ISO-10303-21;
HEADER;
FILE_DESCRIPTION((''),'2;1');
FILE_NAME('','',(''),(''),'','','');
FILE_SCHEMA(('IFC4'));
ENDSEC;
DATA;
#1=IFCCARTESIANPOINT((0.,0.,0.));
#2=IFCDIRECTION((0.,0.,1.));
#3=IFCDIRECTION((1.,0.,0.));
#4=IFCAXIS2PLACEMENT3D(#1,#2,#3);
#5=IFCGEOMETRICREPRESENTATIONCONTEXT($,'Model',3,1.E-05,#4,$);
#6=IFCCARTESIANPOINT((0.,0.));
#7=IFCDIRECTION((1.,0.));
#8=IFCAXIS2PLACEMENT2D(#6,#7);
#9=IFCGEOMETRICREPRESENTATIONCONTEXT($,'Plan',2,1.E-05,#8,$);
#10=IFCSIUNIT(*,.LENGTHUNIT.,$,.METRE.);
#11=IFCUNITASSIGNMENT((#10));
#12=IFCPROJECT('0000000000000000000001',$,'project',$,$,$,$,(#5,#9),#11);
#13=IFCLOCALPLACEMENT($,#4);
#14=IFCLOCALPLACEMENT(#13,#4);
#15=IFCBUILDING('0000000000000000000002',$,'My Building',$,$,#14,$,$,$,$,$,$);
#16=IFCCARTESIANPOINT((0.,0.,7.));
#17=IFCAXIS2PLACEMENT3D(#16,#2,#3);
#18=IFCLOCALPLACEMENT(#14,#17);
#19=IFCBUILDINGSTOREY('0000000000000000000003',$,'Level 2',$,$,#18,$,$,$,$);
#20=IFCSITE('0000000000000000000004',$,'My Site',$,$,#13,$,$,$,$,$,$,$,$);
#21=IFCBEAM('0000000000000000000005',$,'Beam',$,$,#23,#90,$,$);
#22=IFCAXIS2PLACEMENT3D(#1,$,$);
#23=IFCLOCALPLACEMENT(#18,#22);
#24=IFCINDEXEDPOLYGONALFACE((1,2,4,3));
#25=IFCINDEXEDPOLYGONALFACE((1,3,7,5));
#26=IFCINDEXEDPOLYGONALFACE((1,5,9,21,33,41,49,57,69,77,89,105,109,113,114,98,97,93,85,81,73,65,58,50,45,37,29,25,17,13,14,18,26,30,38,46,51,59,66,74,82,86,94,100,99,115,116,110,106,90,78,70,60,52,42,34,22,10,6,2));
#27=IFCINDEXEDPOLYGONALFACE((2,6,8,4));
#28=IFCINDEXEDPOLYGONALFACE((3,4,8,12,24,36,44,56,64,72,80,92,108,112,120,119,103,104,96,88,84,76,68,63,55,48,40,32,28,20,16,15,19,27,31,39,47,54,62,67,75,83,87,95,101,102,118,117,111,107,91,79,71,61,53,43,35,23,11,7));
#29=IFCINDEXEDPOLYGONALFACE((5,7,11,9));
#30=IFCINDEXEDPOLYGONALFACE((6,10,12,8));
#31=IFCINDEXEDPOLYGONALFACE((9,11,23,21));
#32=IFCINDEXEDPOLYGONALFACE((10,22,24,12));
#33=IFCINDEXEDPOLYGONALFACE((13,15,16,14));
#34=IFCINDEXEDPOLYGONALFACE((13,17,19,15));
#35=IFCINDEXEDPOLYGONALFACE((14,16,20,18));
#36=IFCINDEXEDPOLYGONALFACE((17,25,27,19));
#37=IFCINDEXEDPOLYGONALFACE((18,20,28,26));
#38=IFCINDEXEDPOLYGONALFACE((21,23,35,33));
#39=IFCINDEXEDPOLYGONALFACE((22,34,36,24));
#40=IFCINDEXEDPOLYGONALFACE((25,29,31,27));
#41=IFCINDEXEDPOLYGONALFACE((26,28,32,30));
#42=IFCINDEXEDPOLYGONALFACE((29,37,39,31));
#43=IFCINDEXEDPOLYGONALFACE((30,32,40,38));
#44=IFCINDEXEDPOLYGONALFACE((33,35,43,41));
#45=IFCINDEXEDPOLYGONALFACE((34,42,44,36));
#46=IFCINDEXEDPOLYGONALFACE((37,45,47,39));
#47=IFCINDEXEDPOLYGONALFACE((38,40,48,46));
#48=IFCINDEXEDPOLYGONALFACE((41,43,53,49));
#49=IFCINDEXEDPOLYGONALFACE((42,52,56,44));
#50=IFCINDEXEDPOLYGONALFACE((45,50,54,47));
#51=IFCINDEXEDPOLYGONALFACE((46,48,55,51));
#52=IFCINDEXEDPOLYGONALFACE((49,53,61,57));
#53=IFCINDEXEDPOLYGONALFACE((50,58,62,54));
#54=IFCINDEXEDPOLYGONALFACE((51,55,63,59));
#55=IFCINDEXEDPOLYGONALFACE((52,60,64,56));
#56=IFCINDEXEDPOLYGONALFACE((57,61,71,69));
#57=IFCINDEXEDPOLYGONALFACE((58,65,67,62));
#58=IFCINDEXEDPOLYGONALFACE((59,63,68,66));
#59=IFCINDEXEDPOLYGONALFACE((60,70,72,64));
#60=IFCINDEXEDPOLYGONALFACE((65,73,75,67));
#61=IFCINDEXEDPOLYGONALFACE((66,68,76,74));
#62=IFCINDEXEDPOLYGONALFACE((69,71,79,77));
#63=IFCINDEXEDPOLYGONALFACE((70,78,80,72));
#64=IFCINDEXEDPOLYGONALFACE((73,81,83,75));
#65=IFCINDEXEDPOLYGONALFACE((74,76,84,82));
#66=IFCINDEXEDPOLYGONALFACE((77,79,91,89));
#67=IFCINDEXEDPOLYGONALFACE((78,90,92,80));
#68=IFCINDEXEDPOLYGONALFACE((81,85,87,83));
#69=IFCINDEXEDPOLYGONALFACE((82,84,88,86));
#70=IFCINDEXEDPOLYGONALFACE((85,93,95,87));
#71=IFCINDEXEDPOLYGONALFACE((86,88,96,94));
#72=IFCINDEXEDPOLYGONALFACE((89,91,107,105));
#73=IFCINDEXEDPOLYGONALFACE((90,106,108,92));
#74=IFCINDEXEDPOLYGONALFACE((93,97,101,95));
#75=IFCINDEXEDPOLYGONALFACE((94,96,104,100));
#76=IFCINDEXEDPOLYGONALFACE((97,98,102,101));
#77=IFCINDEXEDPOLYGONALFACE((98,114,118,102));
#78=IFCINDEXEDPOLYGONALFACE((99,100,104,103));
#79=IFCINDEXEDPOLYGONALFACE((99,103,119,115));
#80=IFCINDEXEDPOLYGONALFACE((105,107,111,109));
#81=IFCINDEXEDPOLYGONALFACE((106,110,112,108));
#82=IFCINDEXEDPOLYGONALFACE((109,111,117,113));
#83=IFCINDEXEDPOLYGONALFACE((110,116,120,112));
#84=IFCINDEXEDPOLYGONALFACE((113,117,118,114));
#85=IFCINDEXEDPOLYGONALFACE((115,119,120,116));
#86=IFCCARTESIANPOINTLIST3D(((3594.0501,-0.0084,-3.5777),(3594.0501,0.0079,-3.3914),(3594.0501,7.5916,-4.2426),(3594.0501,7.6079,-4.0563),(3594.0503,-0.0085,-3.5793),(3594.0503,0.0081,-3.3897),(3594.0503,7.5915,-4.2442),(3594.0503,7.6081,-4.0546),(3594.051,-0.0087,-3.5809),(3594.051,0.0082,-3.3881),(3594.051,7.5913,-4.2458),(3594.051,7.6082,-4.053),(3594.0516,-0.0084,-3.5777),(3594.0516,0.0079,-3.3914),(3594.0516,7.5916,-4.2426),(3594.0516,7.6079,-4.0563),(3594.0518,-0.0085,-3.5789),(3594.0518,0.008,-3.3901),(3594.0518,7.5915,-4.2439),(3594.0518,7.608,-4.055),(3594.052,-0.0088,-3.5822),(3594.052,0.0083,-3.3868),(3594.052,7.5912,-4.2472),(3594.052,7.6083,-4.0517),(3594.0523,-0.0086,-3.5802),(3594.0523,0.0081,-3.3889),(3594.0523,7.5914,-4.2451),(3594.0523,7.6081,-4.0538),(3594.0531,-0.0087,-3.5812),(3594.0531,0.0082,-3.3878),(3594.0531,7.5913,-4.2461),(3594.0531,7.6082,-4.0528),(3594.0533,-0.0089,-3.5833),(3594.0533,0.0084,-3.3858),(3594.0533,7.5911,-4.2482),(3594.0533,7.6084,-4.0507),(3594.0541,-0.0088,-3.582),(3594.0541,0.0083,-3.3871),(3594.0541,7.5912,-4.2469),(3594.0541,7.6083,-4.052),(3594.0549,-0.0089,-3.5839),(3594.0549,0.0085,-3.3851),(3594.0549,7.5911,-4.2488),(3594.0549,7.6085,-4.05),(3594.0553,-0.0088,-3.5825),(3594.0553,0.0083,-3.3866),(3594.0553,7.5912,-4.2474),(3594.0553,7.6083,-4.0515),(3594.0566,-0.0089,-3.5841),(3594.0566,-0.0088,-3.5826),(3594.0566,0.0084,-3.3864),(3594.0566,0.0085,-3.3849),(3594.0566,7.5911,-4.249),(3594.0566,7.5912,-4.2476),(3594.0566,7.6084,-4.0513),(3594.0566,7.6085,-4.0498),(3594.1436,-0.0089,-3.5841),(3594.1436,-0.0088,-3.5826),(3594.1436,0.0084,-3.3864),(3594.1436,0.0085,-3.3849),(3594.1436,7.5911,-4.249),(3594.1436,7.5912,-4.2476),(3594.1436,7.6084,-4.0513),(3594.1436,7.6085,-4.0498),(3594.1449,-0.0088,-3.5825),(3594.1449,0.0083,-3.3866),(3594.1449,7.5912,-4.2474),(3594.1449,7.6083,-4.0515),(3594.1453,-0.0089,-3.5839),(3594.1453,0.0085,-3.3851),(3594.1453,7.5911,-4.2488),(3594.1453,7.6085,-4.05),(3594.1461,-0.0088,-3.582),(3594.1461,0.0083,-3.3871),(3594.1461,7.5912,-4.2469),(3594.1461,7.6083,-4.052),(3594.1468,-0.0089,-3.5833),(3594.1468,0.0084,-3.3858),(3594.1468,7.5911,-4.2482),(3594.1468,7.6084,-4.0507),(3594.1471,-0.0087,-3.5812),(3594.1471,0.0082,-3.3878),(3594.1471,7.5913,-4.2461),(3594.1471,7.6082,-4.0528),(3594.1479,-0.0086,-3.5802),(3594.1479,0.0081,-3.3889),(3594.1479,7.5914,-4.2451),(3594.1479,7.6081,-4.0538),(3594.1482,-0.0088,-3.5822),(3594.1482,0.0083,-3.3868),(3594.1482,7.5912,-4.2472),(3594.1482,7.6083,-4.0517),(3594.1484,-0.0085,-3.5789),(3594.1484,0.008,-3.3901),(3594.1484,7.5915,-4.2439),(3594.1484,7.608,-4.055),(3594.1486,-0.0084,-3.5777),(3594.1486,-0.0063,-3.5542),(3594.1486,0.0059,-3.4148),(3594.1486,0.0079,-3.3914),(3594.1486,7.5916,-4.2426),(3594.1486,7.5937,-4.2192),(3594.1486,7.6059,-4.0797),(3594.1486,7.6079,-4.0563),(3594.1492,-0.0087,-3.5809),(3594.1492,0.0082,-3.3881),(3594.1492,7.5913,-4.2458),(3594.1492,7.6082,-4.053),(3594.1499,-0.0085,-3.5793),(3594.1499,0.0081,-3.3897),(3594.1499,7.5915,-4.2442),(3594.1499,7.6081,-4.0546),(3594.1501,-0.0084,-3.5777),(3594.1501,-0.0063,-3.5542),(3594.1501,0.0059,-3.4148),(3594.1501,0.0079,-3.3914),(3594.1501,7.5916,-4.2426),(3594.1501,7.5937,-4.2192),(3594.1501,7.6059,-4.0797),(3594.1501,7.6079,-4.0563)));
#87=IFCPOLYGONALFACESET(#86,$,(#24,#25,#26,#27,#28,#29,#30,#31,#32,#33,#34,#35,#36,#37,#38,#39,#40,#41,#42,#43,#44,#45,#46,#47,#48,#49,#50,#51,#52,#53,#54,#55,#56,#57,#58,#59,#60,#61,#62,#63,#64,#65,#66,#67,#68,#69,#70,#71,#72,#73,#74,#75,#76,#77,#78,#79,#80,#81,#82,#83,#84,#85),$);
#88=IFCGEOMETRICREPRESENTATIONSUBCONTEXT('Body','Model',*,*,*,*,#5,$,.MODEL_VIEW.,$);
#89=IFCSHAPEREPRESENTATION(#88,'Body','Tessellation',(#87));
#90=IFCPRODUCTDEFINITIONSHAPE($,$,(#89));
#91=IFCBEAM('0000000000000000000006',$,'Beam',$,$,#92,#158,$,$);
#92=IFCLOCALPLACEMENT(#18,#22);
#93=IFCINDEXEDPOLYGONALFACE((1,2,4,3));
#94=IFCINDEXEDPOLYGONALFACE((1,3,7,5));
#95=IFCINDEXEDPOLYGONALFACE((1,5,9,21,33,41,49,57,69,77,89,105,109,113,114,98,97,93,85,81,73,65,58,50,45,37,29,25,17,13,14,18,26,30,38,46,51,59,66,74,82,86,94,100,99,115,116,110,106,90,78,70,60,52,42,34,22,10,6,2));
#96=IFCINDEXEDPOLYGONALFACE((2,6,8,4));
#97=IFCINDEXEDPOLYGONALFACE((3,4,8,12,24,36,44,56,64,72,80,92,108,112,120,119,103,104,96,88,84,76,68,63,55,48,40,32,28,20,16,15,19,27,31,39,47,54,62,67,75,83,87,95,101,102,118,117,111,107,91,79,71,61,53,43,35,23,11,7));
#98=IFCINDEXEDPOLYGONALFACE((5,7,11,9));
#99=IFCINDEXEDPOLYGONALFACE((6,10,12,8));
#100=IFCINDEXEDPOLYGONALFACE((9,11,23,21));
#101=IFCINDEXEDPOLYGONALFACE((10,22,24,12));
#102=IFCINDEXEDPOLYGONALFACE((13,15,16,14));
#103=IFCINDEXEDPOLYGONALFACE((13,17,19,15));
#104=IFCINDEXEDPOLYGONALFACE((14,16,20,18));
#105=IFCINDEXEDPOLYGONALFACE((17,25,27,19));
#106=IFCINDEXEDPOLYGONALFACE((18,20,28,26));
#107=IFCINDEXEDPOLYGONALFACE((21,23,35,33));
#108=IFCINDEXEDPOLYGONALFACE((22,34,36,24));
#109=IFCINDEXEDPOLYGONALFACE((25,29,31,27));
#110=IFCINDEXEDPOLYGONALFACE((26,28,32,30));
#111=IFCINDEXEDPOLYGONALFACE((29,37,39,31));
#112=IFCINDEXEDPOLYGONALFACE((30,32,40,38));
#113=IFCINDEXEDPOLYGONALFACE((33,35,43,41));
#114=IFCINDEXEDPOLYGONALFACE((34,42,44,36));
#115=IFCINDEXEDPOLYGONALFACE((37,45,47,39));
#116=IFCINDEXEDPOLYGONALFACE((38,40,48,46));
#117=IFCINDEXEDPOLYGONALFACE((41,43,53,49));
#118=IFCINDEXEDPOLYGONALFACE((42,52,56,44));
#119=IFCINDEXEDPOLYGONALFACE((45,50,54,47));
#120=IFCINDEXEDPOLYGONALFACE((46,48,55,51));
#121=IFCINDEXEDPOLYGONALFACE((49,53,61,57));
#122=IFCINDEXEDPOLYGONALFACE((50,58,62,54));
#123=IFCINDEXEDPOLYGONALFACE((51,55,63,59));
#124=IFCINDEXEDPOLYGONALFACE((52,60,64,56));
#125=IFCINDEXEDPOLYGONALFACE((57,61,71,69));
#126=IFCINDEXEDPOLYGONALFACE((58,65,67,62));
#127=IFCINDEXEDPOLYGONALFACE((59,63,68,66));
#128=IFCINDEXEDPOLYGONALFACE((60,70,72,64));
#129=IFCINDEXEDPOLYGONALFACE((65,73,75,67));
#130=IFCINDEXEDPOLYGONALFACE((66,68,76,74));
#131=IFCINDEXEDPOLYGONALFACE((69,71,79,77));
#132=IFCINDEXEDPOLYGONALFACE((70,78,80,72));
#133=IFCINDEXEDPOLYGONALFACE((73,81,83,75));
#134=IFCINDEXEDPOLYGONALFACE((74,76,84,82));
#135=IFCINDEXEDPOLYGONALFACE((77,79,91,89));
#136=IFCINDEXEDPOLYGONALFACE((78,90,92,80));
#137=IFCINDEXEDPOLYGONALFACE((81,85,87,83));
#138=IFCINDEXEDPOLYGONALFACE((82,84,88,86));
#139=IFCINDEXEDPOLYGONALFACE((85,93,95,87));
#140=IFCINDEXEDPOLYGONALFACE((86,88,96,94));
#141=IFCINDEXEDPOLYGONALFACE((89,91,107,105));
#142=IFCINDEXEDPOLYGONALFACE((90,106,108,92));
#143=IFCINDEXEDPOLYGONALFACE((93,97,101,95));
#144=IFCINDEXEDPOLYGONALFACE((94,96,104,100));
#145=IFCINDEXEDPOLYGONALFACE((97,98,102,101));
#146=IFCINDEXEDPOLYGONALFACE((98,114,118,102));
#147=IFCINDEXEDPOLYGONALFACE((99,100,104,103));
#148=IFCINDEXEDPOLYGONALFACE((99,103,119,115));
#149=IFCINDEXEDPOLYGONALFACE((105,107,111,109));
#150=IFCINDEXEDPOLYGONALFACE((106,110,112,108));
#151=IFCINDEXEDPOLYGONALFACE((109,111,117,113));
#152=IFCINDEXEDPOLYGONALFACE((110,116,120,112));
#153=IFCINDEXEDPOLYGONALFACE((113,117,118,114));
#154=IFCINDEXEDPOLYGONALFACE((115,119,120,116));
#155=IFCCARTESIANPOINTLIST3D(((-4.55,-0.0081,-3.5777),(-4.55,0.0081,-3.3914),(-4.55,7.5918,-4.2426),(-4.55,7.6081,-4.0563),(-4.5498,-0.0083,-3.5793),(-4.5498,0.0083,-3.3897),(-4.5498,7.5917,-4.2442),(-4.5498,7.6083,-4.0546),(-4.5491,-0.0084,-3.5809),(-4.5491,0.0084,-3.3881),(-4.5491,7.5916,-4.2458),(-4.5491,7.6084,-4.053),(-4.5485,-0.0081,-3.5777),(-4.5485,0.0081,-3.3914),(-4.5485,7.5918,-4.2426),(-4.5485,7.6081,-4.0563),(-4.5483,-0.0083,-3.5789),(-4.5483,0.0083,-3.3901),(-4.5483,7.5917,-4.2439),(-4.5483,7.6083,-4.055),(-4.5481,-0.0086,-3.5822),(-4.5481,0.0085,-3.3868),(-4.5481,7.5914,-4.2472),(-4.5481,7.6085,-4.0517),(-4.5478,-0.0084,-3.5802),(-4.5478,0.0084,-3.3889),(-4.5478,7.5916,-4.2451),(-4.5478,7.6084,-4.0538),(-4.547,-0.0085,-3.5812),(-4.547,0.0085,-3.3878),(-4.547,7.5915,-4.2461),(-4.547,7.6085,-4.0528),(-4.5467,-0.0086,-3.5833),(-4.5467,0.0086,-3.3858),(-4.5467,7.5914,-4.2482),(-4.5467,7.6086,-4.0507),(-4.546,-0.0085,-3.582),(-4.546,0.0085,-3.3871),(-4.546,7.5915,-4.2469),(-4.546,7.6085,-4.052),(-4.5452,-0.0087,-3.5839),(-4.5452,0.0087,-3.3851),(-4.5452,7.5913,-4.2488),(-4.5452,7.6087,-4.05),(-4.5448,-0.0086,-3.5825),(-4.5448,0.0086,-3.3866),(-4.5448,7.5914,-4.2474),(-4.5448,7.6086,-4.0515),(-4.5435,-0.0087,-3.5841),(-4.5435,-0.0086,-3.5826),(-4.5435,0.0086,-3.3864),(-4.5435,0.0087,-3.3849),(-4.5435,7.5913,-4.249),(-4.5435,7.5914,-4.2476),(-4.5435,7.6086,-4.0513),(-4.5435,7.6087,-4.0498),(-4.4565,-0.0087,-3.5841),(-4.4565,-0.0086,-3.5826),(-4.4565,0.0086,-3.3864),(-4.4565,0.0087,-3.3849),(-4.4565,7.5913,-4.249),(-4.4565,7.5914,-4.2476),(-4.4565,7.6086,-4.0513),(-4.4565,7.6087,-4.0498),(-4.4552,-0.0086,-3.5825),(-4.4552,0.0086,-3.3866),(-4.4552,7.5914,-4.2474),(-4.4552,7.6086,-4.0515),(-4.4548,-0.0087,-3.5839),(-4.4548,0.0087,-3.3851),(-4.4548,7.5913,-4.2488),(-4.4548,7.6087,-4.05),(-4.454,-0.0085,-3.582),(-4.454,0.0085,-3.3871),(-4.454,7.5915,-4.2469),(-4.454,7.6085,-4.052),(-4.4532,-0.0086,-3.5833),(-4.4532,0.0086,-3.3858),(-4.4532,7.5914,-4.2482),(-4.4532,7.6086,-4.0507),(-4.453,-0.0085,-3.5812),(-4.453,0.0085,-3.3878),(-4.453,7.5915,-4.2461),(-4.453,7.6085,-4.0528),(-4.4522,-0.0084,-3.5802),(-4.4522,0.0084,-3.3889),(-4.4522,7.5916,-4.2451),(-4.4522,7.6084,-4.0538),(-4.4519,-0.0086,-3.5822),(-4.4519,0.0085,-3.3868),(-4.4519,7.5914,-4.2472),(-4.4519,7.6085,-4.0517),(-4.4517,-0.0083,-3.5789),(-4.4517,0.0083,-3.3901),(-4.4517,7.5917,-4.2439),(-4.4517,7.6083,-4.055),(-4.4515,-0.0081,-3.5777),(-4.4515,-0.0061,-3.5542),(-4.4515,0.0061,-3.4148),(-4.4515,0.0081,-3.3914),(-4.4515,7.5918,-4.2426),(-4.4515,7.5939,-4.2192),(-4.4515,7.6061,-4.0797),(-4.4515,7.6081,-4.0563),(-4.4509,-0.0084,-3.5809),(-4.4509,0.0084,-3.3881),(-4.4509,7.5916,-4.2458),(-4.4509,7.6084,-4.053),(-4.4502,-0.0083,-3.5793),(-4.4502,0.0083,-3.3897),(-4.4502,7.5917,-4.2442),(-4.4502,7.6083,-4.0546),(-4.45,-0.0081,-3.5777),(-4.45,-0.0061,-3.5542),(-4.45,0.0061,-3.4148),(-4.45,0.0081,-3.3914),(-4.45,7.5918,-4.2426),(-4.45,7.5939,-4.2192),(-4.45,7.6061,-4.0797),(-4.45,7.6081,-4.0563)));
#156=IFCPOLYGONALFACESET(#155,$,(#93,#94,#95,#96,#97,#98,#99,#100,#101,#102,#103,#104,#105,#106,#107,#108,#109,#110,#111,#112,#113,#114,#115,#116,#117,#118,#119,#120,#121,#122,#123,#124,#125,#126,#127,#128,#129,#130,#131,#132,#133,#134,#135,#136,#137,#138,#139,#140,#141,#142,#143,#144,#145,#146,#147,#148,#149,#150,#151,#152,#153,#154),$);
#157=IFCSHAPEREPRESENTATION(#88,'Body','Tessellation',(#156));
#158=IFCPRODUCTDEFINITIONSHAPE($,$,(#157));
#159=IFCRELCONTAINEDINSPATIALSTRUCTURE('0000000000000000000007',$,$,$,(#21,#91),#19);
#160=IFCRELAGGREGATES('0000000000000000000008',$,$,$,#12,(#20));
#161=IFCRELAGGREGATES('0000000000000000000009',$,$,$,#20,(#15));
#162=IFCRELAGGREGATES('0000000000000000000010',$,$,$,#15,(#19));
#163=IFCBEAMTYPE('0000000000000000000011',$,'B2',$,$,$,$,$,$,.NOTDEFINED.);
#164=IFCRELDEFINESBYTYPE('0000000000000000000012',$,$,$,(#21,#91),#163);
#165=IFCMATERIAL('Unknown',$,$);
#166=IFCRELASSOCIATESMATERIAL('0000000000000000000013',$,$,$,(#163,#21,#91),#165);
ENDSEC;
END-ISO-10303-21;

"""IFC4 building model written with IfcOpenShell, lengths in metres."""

from ifc_helpers import new_model, si_unit, frame, origin_with_axes, origin_2d_with_axis, place, context, subcontext, project, spatial, c_section, extrude, material, material_profile, profile_set, profile_usage, type_object, element, save


model = new_model("IFC4")

# Units and contexts
model_context = context("Model", 3, precision=1e-05, world=origin_with_axes())
plan_context = context("Plan", 2, precision=1e-05, world=origin_2d_with_axis())
body_context = subcontext(model_context, "Body", "Model", "MODEL_VIEW")
ifc_project = project(units=[si_unit("LENGTHUNIT", "METRE")], contexts=[model_context, plan_context])

# Site, building, storey
site_placement = place(None, origin_with_axes())
site = spatial("IfcSite", under=ifc_project, at=site_placement, Name="My Site")
building_placement = place(site_placement, origin_with_axes())
building = spatial("IfcBuilding", under=site, at=building_placement, Name="My Building")
storey_placement = place(building_placement, frame((0.0, 0.0, 7.0), z_axis=(0.0, 0.0, 1.0), x_axis=(1.0, 0.0, 0.0)))
storey = spatial("IfcBuildingStorey", under=building, at=storey_placement, Name="Level 2")

# Shared definitions
ifc_material = material(Name="Unknown")

# Beams
ifc_material_profile_1 = material_profile(ifc_material, c_section(Depth=0.2, Width=0.1, WallThickness=0.0015, Girth=0.03, InternalFilletRadius=0.005))
ifc_profile_set_1 = profile_set([ifc_material_profile_1])
beam_type_1 = type_object("IfcBeamType", Name="B2", PredefinedType="NOTDEFINED", material=ifc_profile_set_1)
ifc_profile_usage_1 = profile_usage(ifc_profile_set_1, cardinal=5)
beam_1_placement = place(storey_placement, frame((3594.1001, 7.5998, -4.1494), z_axis=(0.0, -0.996195, 0.087156), x_axis=(1.0, 0.0, 0.0)))
element("IfcBeam", 1, at=beam_1_placement, inside=storey, type_object=beam_type_1, material=ifc_profile_usage_1, Name="Beam", context=body_context, shape_type="SweptSolid", body=[
    extrude(c_section(Depth=0.2, Width=0.1, WallThickness=0.0015, Girth=0.03, InternalFilletRadius=0.005), origin_with_axes(), (0.0, 0.0, 1.0), 7.629),
])
ifc_profile_usage_2 = profile_usage(ifc_profile_set_1, cardinal=5)
beam_2_placement = place(storey_placement, frame((-4.5, 7.6, -4.1494), z_axis=(0.0, -0.996195, 0.087156), x_axis=(1.0, 0.0, 0.0)))
element("IfcBeam", 2, at=beam_2_placement, inside=storey, type_object=beam_type_1, material=ifc_profile_usage_2, Name="Beam", context=body_context, shape_type="SweptSolid", body=[
    extrude(c_section(Depth=0.2, Width=0.1, WallThickness=0.0015, Girth=0.03, InternalFilletRadius=0.005), origin_with_axes(), (0.0, 0.0, 1.0), 7.629),
])

save(model, "model.ifc")
